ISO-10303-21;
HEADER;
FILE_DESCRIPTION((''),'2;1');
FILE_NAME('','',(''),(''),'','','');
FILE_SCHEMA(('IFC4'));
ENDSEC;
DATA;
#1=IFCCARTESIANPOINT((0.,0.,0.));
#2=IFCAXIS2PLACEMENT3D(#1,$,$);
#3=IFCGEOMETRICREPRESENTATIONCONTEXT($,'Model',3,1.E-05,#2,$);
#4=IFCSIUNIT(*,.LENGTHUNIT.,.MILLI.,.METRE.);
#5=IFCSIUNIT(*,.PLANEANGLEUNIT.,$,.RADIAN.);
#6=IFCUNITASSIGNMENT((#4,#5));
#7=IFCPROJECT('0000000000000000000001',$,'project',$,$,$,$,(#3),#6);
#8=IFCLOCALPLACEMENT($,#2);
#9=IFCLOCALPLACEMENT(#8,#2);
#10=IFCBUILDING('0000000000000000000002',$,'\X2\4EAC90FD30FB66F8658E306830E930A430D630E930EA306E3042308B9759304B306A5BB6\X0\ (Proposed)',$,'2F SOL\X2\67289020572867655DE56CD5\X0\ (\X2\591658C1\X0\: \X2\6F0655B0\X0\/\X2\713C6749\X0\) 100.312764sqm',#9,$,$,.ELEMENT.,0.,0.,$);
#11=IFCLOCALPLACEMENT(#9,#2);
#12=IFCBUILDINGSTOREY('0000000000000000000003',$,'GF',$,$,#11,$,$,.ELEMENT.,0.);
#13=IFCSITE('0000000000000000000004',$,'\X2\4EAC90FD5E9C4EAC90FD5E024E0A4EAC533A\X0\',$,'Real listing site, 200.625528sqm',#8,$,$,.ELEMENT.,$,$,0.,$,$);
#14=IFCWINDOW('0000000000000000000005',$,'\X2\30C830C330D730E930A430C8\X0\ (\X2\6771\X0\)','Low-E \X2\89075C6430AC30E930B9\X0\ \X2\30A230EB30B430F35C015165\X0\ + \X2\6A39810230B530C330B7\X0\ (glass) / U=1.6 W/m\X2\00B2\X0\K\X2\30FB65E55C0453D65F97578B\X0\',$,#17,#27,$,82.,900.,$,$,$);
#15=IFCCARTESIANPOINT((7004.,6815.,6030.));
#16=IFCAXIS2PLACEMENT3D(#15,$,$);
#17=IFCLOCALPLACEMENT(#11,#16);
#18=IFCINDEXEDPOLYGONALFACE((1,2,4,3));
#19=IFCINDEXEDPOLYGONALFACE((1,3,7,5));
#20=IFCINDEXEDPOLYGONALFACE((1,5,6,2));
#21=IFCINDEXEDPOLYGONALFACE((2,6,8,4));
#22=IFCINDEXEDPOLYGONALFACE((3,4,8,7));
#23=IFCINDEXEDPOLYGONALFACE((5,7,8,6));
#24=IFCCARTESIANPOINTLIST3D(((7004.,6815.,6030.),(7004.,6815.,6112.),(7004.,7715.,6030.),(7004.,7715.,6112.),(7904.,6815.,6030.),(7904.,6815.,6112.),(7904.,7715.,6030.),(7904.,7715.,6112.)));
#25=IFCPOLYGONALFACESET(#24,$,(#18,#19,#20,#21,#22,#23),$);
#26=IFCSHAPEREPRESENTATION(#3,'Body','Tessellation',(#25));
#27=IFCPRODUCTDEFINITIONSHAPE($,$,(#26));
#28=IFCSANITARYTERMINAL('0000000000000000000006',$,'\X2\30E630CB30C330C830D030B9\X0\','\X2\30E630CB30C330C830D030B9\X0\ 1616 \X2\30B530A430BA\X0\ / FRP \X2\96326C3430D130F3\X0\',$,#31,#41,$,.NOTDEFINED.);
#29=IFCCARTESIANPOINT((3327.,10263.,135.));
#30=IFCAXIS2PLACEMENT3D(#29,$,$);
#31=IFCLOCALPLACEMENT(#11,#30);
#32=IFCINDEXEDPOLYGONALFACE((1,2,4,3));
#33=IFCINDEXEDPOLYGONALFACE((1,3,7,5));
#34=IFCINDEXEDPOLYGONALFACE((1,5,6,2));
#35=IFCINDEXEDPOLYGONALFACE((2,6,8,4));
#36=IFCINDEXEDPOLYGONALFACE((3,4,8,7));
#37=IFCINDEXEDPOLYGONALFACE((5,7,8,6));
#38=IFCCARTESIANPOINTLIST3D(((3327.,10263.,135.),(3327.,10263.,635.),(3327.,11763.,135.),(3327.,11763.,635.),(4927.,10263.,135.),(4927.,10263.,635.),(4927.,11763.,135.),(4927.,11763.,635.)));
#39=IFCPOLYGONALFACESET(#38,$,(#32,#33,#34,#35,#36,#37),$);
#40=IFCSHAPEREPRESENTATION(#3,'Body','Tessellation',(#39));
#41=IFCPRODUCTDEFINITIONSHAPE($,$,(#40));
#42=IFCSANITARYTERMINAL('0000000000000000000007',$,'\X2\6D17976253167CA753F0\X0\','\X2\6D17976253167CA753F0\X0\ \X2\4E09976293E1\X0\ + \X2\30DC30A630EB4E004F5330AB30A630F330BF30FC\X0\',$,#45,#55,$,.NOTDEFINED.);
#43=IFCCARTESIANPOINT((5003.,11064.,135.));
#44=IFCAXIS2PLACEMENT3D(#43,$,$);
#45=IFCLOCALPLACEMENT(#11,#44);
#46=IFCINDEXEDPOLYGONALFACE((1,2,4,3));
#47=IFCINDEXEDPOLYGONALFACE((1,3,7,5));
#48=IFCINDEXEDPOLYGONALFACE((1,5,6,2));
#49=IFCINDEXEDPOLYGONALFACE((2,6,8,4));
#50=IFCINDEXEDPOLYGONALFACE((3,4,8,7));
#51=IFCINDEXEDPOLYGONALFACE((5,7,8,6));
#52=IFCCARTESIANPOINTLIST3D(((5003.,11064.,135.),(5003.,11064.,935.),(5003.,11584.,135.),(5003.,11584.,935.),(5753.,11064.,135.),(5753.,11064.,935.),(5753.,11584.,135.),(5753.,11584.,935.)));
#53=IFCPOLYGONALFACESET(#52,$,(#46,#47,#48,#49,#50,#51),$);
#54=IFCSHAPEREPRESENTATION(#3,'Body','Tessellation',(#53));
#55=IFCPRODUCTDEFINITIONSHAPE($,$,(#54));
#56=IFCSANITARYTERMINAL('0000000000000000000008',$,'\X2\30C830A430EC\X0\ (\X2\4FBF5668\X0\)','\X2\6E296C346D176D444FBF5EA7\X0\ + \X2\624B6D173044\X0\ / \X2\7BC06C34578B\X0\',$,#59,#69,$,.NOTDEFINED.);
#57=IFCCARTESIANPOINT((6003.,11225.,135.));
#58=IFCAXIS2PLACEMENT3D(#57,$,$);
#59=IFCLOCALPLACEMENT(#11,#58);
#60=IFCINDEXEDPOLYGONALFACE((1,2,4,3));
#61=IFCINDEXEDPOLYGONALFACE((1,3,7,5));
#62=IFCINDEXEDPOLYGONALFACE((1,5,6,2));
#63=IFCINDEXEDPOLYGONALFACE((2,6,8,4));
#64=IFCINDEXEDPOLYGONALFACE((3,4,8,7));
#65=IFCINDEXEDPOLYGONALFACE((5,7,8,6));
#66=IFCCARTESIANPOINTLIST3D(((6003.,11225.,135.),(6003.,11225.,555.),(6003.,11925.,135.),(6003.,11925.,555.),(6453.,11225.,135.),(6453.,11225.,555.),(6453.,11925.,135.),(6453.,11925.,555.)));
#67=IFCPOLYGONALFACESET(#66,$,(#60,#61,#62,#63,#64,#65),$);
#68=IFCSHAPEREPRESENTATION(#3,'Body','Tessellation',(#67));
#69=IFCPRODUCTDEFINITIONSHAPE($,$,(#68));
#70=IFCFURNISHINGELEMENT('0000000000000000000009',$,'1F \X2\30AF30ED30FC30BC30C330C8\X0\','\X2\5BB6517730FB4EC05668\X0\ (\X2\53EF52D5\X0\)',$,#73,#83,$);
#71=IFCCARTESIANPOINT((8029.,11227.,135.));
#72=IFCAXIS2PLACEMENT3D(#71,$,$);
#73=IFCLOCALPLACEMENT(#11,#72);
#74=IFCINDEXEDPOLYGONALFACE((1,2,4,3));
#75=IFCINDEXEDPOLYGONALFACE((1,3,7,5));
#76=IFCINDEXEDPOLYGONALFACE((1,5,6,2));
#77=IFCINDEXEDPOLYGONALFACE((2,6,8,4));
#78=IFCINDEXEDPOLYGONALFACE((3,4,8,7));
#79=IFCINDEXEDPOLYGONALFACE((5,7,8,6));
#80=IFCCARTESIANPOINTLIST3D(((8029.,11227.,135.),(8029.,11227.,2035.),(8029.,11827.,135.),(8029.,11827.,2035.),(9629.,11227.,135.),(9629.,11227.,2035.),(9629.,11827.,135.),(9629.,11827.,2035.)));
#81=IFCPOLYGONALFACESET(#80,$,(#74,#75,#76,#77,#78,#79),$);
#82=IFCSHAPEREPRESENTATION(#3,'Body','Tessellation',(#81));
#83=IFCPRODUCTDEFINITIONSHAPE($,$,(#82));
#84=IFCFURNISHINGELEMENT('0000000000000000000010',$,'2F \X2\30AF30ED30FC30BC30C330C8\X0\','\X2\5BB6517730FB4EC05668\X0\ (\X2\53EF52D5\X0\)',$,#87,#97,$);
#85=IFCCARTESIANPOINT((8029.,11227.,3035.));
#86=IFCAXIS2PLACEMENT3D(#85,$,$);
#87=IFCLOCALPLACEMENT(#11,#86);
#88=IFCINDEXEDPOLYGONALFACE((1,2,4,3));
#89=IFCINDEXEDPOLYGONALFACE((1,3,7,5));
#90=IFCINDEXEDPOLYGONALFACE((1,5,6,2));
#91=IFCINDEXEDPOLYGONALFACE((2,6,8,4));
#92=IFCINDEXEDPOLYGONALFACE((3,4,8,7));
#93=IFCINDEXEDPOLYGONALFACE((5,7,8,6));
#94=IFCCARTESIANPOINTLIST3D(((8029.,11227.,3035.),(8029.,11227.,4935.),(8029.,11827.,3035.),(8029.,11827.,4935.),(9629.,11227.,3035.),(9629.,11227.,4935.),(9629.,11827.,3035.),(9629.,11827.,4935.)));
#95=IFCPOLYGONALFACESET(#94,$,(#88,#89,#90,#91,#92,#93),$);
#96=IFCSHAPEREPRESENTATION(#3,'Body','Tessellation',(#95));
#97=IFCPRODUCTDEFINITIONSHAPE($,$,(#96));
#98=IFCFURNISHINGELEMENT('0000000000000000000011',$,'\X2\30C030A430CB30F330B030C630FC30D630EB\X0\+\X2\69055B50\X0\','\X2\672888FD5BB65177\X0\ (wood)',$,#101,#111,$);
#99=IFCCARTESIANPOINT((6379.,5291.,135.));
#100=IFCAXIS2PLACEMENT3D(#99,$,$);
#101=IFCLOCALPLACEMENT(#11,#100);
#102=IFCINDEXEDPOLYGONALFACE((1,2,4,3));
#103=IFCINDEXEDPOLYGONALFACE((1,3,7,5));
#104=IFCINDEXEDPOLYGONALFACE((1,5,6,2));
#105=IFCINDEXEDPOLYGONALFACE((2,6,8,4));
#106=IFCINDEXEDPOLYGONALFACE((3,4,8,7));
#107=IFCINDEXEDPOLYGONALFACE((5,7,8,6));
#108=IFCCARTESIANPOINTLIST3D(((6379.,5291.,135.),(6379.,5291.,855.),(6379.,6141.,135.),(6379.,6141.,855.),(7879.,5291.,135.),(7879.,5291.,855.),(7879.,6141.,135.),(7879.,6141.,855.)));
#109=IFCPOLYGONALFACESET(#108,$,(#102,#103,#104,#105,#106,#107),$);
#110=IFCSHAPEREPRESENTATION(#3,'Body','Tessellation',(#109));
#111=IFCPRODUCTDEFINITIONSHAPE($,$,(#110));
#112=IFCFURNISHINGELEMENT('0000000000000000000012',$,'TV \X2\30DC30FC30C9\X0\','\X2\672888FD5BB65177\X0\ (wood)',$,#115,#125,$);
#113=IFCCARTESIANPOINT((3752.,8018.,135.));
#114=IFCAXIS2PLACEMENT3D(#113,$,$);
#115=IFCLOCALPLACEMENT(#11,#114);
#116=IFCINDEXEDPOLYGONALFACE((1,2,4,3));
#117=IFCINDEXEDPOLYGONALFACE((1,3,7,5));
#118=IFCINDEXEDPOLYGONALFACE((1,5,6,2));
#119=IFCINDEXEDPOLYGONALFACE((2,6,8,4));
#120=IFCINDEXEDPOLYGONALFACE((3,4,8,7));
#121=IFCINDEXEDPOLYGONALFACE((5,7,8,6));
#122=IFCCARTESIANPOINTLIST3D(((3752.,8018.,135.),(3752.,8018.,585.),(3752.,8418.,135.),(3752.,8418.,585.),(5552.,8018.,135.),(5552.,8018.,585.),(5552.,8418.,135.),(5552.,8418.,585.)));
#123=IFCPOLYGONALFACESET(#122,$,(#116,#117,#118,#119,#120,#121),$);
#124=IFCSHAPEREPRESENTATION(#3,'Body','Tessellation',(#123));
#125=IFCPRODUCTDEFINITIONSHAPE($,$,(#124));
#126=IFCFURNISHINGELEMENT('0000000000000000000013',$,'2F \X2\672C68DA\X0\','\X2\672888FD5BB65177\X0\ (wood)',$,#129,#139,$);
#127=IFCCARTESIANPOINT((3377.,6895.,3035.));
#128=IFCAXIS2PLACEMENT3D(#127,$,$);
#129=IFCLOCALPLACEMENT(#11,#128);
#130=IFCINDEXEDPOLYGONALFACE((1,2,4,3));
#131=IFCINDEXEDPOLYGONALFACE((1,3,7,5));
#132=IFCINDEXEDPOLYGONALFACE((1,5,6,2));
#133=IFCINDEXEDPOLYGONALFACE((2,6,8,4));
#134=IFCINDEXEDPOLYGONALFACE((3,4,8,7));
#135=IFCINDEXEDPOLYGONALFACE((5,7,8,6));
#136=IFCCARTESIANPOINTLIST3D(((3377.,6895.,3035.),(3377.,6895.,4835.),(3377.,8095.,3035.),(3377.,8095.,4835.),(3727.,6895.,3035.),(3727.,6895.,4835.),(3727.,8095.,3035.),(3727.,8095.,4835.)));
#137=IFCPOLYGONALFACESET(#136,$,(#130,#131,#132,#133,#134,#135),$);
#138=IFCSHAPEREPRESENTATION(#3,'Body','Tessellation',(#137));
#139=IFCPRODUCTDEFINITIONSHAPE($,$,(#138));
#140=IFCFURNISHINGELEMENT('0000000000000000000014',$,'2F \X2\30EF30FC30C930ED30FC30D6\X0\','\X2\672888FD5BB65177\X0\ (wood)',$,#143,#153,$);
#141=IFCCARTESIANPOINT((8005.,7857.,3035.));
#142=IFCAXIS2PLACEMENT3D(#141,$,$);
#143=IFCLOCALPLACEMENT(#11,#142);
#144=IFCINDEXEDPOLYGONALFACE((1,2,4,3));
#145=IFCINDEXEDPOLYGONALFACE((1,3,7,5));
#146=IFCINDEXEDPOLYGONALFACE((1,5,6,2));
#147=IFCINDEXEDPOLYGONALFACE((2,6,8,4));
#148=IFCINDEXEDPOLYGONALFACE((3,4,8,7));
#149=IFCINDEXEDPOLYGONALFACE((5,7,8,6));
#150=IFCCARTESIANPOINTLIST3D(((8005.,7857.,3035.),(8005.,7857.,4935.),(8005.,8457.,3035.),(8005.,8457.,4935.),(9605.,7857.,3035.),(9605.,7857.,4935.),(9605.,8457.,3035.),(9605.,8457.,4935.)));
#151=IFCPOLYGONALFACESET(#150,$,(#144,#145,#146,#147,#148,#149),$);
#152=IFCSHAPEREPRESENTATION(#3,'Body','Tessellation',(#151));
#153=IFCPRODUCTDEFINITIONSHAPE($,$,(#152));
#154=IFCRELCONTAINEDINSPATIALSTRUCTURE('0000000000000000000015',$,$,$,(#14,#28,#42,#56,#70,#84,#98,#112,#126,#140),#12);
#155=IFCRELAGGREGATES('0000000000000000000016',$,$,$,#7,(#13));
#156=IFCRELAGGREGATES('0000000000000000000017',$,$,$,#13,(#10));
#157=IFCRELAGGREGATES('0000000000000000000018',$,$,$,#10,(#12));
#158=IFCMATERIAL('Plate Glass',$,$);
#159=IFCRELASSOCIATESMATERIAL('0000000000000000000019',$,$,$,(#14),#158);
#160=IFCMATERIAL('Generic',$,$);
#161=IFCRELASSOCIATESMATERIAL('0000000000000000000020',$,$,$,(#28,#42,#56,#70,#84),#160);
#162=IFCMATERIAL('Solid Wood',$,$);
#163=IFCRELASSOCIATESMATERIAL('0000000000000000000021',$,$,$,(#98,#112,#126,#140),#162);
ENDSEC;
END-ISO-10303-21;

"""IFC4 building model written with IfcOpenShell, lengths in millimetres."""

from ifc_helpers import new_model, si_unit, frame, frame_2d, origin, place, context, project, spatial, rectangle, extrude, material, element, save


model = new_model("IFC4")

# Units and contexts
model_context = context("Model", 3, precision=1e-05, world=origin())
ifc_project = project(units=[si_unit("LENGTHUNIT", "METRE", prefix="MILLI"), si_unit("PLANEANGLEUNIT", "RADIAN")], contexts=[model_context])

# Site, building, storey
site_placement = place(None, origin())
site = spatial("IfcSite", under=ifc_project, at=site_placement, Name="京都府京都市上京区", ObjectType="Real listing site, 200.625528sqm", CompositionType="ELEMENT", RefElevation=0.0)
building_placement = place(site_placement, origin())
building = spatial("IfcBuilding", under=site, at=building_placement, Name="京都・書斎とライブラリのある静かな家 (Proposed)", ObjectType="2F SOL木造在来工法 (外壁: 漆喰/焼杉) 100.312764sqm", CompositionType="ELEMENT", ElevationOfRefHeight=0.0, ElevationOfTerrain=0.0)
storey_placement = place(building_placement, origin())
storey = spatial("IfcBuildingStorey", under=building, at=storey_placement, Name="GF", CompositionType="ELEMENT", Elevation=0.0)

# Shared definitions
ifc_material_1 = material(Name="Solid Wood")
ifc_material_2 = material(Name="Plate Glass")

# Window
window_1_placement = place(storey_placement, frame((7004.0, 6815.0, 6030.0)))
element("IfcWindow", 1, at=window_1_placement, inside=storey, material=ifc_material_2, Name="トップライト (東)", Description="Low-E 複層ガラス アルゴン封入 + 樹脂サッシ (glass) / U=1.6 W/m²K・日射取得型", OverallHeight=82.0, OverallWidth=900.0, context=model_context, shape_type="SweptSolid", body=[
    extrude(rectangle(XDim=900.0, YDim=900.0, at=frame_2d((450.0, 450.0))), frame((7004.0, 6815.0, 6030.0)), (0.0, 0.0, 1.0), 82.0),
])

# Sanitary terminals
ifc_material_3 = material(Name="Generic")
sanitary_terminal_1_placement = place(storey_placement, frame((3327.0, 10263.0, 135.0)))
element("IfcSanitaryTerminal", 2, at=sanitary_terminal_1_placement, inside=storey, material=ifc_material_3, Name="ユニットバス", Description="ユニットバス 1616 サイズ / FRP 防水パン", PredefinedType="NOTDEFINED", context=model_context, shape_type="SweptSolid", body=[
    extrude(rectangle(XDim=1600.0, YDim=1500.0, at=frame_2d((800.0, 750.0))), frame((3327.0, 10263.0, 135.0)), (0.0, 0.0, 1.0), 500.0),
])
sanitary_terminal_2_placement = place(storey_placement, frame((5003.0, 11064.0, 135.0)))
element("IfcSanitaryTerminal", 3, at=sanitary_terminal_2_placement, inside=storey, material=ifc_material_3, Name="洗面化粧台", Description="洗面化粧台 三面鏡 + ボウル一体カウンター", PredefinedType="NOTDEFINED", context=model_context, shape_type="SweptSolid", body=[
    extrude(rectangle(XDim=750.0, YDim=520.0, at=frame_2d((375.0, 260.0))), frame((5003.0, 11064.0, 135.0)), (0.0, 0.0, 1.0), 800.0),
])
sanitary_terminal_3_placement = place(storey_placement, frame((6003.0, 11225.0, 135.0)))
element("IfcSanitaryTerminal", 4, at=sanitary_terminal_3_placement, inside=storey, material=ifc_material_3, Name="トイレ (便器)", Description="温水洗浄便座 + 手洗い / 節水型", PredefinedType="NOTDEFINED", context=model_context, shape_type="SweptSolid", body=[
    extrude(rectangle(XDim=450.0, YDim=700.0, at=frame_2d((225.0, 350.0))), frame((6003.0, 11225.0, 135.0)), (0.0, 0.0, 1.0), 420.0),
])

# Furnishing elements
furnishing_1_placement = place(storey_placement, frame((8029.0, 11227.0, 135.0)))
element("IfcFurnishingElement", 5, at=furnishing_1_placement, inside=storey, material=ifc_material_3, Name="1F クローゼット", Description="家具・什器 (可動)", context=model_context, shape_type="SweptSolid", body=[
    extrude(rectangle(XDim=1600.0, YDim=600.0, at=frame_2d((800.0, 300.0))), frame((8029.0, 11227.0, 135.0)), (0.0, 0.0, 1.0), 1900.0),
])
furnishing_2_placement = place(storey_placement, frame((8029.0, 11227.0, 3035.0)))
element("IfcFurnishingElement", 6, at=furnishing_2_placement, inside=storey, material=ifc_material_3, Name="2F クローゼット", Description="家具・什器 (可動)", context=model_context, shape_type="SweptSolid", body=[
    extrude(rectangle(XDim=1600.0, YDim=600.0, at=frame_2d((800.0, 300.0))), frame((8029.0, 11227.0, 3035.0)), (0.0, 0.0, 1.0), 1900.0),
])
furnishing_3_placement = place(storey_placement, frame((6379.0, 5291.0, 135.0)))
element("IfcFurnishingElement", 7, at=furnishing_3_placement, inside=storey, material=ifc_material_1, Name="ダイニングテーブル+椅子", Description="木製家具 (wood)", context=model_context, shape_type="SweptSolid", body=[
    extrude(rectangle(XDim=1500.0, YDim=850.0, at=frame_2d((750.0, 425.0))), frame((6379.0, 5291.0, 135.0)), (0.0, 0.0, 1.0), 720.0),
])
furnishing_4_placement = place(storey_placement, frame((3752.0, 8018.0, 135.0)))
element("IfcFurnishingElement", 8, at=furnishing_4_placement, inside=storey, material=ifc_material_1, Name="TV ボード", Description="木製家具 (wood)", context=model_context, shape_type="SweptSolid", body=[
    extrude(rectangle(XDim=1800.0, YDim=400.0, at=frame_2d((900.0, 200.0))), frame((3752.0, 8018.0, 135.0)), (0.0, 0.0, 1.0), 450.0),
])
furnishing_5_placement = place(storey_placement, frame((3377.0, 6895.0, 3035.0)))
element("IfcFurnishingElement", 9, at=furnishing_5_placement, inside=storey, material=ifc_material_1, Name="2F 本棚", Description="木製家具 (wood)", context=model_context, shape_type="SweptSolid", body=[
    extrude(rectangle(XDim=350.0, YDim=1200.0, at=frame_2d((175.0, 600.0))), frame((3377.0, 6895.0, 3035.0)), (0.0, 0.0, 1.0), 1800.0),
])
furnishing_6_placement = place(storey_placement, frame((8005.0, 7857.0, 3035.0)))
element("IfcFurnishingElement", 10, at=furnishing_6_placement, inside=storey, material=ifc_material_1, Name="2F ワードローブ", Description="木製家具 (wood)", context=model_context, shape_type="SweptSolid", body=[
    extrude(rectangle(XDim=1600.0, YDim=600.0, at=frame_2d((800.0, 300.0))), frame((8005.0, 7857.0, 3035.0)), (0.0, 0.0, 1.0), 1900.0),
])

save(model, "model.ifc")
